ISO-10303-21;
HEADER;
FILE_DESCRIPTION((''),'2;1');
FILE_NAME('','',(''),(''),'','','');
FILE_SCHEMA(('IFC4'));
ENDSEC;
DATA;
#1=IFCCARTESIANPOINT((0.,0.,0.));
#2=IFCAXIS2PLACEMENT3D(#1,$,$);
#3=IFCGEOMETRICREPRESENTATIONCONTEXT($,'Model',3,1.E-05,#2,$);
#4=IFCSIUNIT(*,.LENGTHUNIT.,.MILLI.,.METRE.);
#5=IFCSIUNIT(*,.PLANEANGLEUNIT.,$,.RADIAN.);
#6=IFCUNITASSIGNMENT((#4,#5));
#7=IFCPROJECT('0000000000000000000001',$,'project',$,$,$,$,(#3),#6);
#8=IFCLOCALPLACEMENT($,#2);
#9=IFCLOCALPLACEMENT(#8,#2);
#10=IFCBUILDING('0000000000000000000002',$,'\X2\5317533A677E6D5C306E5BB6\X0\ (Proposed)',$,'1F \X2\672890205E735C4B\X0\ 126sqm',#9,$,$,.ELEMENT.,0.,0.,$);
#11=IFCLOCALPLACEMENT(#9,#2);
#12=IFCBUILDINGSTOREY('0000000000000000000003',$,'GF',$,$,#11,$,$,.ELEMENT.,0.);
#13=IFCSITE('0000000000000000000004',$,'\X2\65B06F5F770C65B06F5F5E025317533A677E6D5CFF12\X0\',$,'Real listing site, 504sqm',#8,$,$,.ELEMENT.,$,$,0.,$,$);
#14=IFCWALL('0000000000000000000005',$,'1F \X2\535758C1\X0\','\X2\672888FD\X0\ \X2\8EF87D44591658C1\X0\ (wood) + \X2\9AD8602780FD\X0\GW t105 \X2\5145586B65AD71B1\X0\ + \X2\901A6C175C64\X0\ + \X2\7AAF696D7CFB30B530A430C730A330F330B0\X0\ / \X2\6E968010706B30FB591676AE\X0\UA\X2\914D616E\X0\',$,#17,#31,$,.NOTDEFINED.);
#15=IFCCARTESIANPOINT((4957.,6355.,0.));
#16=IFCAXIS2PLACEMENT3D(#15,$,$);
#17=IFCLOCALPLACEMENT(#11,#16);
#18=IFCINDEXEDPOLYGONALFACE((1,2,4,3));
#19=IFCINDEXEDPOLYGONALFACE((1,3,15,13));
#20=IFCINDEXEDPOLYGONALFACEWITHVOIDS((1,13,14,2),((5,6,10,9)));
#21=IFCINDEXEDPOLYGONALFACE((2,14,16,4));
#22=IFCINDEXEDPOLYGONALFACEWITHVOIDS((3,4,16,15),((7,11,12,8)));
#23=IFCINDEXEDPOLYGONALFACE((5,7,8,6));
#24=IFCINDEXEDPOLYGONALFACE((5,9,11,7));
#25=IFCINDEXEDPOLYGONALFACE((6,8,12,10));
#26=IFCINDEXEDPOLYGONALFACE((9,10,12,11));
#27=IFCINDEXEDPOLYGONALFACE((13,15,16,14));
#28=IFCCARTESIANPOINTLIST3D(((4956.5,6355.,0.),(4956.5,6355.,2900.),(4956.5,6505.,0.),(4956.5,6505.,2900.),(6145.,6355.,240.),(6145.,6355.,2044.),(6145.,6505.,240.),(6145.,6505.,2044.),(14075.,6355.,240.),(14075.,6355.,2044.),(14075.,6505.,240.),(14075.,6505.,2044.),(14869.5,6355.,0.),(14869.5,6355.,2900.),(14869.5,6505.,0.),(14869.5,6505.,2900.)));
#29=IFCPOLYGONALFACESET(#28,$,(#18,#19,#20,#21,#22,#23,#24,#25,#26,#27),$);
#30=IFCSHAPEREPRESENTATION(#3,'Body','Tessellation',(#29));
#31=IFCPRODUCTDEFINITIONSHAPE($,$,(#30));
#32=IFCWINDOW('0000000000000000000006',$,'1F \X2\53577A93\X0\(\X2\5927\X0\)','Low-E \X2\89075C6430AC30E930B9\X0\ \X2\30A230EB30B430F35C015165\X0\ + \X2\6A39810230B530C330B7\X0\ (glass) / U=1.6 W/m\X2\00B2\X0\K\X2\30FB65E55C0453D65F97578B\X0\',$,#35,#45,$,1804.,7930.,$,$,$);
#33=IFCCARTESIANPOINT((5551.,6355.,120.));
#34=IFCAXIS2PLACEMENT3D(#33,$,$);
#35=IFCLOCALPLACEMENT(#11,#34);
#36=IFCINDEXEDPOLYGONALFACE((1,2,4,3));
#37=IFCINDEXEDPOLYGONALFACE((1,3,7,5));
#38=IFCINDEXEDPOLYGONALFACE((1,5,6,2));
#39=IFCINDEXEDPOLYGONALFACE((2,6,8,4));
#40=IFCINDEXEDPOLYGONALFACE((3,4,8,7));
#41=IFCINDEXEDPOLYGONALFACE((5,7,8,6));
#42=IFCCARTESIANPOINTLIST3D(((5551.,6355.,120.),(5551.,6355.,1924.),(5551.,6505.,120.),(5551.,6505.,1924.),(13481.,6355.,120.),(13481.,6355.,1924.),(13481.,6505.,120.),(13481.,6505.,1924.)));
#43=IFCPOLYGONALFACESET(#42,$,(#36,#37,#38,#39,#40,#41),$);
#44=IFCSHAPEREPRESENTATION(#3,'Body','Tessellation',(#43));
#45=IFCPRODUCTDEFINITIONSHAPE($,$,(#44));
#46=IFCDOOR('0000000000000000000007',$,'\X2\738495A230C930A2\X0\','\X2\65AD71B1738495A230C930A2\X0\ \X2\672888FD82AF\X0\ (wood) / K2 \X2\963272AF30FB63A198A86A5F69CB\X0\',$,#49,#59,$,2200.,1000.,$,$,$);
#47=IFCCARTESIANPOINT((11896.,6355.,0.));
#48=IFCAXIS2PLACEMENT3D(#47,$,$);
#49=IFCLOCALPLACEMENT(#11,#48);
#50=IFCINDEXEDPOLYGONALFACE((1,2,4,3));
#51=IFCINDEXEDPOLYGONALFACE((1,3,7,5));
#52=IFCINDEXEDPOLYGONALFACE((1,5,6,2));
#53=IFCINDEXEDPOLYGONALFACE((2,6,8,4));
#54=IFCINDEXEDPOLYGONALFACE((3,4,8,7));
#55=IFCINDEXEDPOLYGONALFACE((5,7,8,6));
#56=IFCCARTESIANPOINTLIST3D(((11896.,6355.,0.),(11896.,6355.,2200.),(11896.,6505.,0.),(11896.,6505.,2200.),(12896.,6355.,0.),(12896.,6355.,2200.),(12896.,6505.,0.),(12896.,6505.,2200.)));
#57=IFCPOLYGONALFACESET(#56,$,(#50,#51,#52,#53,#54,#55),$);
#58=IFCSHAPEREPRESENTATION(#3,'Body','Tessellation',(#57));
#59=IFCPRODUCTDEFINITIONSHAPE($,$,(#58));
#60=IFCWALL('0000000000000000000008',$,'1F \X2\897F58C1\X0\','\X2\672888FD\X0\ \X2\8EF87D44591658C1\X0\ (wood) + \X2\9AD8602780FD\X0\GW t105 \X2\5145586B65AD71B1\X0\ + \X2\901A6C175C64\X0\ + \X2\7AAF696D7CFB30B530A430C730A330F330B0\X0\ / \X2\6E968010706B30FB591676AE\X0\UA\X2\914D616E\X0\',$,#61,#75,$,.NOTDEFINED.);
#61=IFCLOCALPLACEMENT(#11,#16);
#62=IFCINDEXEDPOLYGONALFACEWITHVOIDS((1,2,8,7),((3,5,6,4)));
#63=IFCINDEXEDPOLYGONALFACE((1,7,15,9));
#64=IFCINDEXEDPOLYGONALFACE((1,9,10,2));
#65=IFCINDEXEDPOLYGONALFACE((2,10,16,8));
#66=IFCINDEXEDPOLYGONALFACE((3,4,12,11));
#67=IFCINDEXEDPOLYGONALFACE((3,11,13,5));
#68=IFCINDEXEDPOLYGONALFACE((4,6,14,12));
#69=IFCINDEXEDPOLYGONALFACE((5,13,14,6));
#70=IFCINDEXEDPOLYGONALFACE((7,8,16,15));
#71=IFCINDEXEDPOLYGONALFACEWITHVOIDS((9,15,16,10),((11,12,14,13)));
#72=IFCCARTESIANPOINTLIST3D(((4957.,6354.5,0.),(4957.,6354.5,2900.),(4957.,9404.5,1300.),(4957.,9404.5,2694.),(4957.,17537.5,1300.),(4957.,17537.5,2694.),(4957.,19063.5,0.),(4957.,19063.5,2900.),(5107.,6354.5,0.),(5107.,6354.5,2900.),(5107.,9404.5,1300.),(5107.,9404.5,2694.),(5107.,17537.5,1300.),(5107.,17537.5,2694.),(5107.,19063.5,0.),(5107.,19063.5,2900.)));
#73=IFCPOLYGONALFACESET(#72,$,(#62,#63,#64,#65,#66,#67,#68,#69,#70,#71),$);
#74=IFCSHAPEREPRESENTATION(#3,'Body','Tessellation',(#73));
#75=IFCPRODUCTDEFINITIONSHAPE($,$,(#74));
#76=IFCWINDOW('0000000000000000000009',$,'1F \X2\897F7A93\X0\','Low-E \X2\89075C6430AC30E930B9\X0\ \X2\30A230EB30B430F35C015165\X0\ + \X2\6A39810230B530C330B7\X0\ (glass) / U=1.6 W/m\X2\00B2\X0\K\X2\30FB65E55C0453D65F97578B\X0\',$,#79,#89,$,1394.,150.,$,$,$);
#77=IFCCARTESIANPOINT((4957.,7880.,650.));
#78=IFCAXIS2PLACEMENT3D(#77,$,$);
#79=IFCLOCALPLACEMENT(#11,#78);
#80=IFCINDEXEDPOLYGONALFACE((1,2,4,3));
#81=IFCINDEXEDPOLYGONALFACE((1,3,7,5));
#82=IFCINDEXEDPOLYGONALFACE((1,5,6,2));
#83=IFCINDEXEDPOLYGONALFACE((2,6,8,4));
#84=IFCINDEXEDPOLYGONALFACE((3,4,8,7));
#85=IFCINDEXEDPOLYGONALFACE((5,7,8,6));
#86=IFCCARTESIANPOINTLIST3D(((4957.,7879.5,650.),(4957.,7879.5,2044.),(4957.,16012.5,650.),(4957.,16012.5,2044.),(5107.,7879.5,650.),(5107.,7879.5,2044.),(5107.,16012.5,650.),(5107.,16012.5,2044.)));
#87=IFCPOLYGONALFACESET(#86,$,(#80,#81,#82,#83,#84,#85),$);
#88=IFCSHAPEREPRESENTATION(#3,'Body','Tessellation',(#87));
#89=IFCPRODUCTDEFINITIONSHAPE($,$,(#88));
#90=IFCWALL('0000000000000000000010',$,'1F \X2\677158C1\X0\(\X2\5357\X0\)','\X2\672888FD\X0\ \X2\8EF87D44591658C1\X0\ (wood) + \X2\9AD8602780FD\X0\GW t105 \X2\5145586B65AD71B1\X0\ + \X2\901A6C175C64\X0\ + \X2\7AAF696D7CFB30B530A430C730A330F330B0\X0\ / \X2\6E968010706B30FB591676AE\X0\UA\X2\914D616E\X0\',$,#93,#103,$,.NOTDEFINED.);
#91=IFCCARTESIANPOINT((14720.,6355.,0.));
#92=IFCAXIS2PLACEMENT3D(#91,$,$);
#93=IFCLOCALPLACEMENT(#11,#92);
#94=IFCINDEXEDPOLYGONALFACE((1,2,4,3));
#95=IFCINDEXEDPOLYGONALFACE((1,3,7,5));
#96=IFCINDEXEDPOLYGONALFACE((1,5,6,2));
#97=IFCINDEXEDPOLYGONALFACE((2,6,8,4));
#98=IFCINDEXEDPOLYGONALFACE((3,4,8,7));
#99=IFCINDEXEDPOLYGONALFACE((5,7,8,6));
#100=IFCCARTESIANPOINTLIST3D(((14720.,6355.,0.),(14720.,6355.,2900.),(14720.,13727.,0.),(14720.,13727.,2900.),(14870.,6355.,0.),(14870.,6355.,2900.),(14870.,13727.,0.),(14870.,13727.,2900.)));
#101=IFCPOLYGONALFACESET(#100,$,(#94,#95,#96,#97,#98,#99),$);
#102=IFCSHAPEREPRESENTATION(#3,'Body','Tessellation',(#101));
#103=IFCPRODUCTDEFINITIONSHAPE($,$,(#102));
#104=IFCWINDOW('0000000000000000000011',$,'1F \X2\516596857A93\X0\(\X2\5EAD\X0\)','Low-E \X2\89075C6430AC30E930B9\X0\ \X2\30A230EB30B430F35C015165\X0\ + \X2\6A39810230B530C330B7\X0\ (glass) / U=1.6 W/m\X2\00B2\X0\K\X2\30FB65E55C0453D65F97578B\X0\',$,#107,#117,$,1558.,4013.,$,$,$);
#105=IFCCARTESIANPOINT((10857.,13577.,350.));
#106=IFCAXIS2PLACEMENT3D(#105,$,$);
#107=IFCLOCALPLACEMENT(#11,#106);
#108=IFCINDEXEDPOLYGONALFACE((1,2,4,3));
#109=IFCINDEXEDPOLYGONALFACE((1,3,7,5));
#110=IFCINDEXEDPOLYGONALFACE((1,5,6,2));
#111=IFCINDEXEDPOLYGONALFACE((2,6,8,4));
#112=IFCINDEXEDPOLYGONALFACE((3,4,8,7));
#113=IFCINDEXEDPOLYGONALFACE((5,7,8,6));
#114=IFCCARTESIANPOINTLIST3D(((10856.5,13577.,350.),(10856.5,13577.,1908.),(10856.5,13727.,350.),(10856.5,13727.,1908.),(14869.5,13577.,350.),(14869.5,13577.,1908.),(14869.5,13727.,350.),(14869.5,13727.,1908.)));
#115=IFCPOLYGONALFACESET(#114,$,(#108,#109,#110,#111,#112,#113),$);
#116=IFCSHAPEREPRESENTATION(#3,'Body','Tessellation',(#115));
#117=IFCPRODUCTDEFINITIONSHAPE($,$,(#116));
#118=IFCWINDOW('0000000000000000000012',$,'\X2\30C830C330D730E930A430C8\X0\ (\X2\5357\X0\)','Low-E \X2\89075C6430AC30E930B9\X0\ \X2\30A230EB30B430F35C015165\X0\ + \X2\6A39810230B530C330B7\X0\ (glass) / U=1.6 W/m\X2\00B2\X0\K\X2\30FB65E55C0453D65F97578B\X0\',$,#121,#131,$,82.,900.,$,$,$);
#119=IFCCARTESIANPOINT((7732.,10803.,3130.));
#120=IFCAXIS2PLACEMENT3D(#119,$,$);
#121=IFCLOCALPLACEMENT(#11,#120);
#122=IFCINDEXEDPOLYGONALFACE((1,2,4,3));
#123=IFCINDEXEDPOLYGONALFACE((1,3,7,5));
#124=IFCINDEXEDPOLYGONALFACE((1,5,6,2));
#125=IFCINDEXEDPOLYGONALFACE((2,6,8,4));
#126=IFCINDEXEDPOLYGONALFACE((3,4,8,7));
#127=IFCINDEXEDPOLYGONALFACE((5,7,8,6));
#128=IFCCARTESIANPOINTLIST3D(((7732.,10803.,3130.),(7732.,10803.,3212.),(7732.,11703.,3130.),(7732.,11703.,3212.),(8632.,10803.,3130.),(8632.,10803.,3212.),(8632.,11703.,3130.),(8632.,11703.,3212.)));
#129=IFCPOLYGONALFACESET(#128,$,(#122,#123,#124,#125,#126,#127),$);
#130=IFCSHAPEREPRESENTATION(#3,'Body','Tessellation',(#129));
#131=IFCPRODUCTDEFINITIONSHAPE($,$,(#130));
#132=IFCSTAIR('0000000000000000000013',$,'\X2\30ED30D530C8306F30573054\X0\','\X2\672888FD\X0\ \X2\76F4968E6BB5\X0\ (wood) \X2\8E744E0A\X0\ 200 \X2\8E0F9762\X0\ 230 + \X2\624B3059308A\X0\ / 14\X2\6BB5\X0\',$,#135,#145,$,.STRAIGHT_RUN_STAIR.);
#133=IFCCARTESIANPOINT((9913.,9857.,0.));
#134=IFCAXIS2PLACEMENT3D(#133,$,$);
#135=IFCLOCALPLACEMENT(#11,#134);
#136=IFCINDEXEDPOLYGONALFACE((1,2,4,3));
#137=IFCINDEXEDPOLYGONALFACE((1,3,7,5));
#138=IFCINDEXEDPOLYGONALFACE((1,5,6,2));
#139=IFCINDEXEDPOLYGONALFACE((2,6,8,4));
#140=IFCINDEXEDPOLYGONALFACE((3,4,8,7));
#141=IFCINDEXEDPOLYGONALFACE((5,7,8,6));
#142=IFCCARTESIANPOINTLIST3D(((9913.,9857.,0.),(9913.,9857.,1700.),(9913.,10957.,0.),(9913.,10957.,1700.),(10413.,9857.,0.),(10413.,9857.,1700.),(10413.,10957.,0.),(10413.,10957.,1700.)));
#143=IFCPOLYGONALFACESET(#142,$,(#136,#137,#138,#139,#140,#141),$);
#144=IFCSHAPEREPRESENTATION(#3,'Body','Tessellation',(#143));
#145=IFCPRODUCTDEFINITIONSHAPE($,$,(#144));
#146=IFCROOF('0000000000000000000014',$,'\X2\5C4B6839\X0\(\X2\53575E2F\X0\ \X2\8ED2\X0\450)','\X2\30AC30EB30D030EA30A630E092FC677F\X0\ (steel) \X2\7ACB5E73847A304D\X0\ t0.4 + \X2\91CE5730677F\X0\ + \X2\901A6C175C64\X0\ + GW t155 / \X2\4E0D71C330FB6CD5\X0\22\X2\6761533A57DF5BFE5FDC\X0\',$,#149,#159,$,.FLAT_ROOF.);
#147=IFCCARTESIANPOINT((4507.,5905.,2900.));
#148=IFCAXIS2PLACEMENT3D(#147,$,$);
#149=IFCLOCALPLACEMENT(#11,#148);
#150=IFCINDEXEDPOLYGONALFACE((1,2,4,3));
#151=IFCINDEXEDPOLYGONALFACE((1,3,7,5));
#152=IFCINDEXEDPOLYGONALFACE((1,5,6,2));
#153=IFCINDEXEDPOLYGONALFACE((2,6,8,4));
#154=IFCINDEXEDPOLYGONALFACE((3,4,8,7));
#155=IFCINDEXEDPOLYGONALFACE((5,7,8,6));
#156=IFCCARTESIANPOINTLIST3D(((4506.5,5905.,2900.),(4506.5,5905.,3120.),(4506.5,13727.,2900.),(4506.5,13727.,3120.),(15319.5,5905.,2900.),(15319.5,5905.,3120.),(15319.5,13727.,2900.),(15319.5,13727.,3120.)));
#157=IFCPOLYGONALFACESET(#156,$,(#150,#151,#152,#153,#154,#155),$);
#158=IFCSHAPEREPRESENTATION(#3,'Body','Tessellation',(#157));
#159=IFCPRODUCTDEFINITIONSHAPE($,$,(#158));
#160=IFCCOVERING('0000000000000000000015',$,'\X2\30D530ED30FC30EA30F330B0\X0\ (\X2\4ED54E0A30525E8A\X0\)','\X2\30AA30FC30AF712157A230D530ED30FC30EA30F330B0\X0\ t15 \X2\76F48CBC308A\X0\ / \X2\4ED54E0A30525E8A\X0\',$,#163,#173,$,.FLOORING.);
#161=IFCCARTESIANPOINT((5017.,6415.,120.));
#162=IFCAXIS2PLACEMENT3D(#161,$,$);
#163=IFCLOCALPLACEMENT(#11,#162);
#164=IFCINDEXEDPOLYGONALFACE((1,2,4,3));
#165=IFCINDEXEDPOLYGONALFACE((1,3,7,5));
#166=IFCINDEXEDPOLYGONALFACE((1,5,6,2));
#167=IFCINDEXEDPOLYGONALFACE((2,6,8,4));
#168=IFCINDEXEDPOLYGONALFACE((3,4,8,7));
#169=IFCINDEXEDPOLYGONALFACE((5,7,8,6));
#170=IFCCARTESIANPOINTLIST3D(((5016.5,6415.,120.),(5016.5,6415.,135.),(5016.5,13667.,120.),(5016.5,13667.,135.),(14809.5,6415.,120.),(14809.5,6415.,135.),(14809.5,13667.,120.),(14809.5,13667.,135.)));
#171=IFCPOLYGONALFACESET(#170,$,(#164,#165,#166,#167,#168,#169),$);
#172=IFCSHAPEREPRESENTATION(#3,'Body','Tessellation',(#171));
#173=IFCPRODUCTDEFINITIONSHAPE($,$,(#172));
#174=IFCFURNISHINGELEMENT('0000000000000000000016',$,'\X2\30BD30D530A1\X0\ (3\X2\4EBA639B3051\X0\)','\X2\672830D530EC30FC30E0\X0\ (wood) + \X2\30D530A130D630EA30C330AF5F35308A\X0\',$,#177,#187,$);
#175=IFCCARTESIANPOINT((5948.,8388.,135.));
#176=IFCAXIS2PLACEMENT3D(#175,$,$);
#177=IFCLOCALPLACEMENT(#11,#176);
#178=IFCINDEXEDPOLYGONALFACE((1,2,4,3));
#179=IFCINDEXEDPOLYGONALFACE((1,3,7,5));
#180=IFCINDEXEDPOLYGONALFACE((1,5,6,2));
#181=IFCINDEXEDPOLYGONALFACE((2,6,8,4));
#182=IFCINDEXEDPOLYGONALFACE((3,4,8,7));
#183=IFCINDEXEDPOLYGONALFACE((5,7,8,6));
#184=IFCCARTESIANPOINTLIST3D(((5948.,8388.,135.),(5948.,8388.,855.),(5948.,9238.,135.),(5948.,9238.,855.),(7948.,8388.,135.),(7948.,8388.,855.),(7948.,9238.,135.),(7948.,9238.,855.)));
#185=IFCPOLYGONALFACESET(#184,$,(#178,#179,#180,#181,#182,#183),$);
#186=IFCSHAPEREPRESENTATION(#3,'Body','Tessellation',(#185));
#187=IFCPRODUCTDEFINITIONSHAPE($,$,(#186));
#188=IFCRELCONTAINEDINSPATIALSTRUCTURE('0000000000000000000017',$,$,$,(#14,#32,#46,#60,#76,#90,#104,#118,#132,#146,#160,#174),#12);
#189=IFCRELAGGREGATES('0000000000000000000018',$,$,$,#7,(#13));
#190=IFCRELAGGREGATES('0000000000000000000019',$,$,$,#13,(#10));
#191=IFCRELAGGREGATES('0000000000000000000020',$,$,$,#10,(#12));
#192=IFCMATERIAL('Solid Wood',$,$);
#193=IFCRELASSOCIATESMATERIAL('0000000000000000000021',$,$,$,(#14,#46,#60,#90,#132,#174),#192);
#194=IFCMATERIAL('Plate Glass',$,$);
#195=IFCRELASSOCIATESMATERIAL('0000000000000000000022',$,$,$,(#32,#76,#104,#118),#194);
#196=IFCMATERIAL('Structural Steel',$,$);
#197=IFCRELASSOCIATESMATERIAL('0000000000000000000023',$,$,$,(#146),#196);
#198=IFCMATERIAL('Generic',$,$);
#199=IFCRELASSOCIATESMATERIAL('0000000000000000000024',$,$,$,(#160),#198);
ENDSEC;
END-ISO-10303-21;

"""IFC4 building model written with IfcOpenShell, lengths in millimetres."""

from ifc_helpers import new_model, si_unit, frame, frame_2d, origin, place, context, project, spatial, rectangle, extrude, material, element, fill, save


model = new_model("IFC4")

# Units and contexts
model_context = context("Model", 3, precision=1e-05, world=origin())
ifc_project = project(units=[si_unit("LENGTHUNIT", "METRE", prefix="MILLI"), si_unit("PLANEANGLEUNIT", "RADIAN")], contexts=[model_context])

# Site, building, storey
site_placement = place(None, origin())
site = spatial("IfcSite", under=ifc_project, at=site_placement, Name="新潟県新潟市北区松浜２", ObjectType="Real listing site, 504sqm", CompositionType="ELEMENT", RefElevation=0.0)
building_placement = place(site_placement, origin())
building = spatial("IfcBuilding", under=site, at=building_placement, Name="北区松浜の家 (Proposed)", ObjectType="1F 木造平屋 126sqm", CompositionType="ELEMENT", ElevationOfRefHeight=0.0, ElevationOfTerrain=0.0)
storey_placement = place(building_placement, origin())
storey = spatial("IfcBuildingStorey", under=building, at=storey_placement, Name="GF", CompositionType="ELEMENT", Elevation=0.0)

# Shared definitions
ifc_material_1 = material(Name="Solid Wood")

# Wall, openings, window, door
wall_1_placement = place(storey_placement, frame((4957.0, 6355.0, 0.0)))
wall_1 = element("IfcWall", 1, at=wall_1_placement, inside=storey, material=ifc_material_1, Name="1F 南壁", Description="木製 軸組外壁 (wood) + 高性能GW t105 充填断熱 + 通気層 + 窯業系サイディング / 準耐火・外皮UA配慮", PredefinedType="NOTDEFINED", context=model_context, shape_type="SweptSolid", body=[
    extrude(rectangle(XDim=9913.0, YDim=150.0, at=frame_2d((4956.0, 75.0))), frame((4957.0, 6355.0, 0.0)), (0.0, 0.0, 1.0), 2900.0),
])
opening_1_placement = place(storey_placement, frame((5551.0, 6355.0, 120.0)))
opening_1 = element("IfcOpeningElement", 2, at=opening_1_placement, cuts=wall_1, PredefinedType="NOTDEFINED", context=model_context, shape_type="SweptSolid", body=[
    extrude(rectangle(XDim=7930.0, YDim=150.0, at=frame_2d((3965.0, 75.0))), frame((5551.0, 6355.0, 120.0)), (0.0, 0.0, 1.0), 1804.0),
])
opening_2_placement = place(storey_placement, frame((11896.0, 6355.0, 0.0)))
opening_2 = element("IfcOpeningElement", 3, at=opening_2_placement, cuts=wall_1, PredefinedType="NOTDEFINED", context=model_context, shape_type="SweptSolid", body=[
    extrude(rectangle(XDim=1000.0, YDim=150.0, at=frame_2d((500.0, 75.0))), frame((11896.0, 6355.0, 0.0)), (0.0, 0.0, 1.0), 2200.0),
])
ifc_material_2 = material(Name="Plate Glass")
window_1_placement = place(storey_placement, frame((5551.0, 6355.0, 120.0)))
window_1 = element("IfcWindow", 4, at=window_1_placement, inside=storey, material=ifc_material_2, Name="1F 南窓(大)", Description="Low-E 複層ガラス アルゴン封入 + 樹脂サッシ (glass) / U=1.6 W/m²K・日射取得型", OverallHeight=1804.0, OverallWidth=7930.0, context=model_context, shape_type="SweptSolid", body=[
    extrude(rectangle(XDim=7930.0, YDim=150.0, at=frame_2d((3965.0, 75.0))), frame((5551.0, 6355.0, 120.0)), (0.0, 0.0, 1.0), 1804.0),
])
fill(opening_1, window_1)
door_1_placement = place(storey_placement, frame((11896.0, 6355.0, 0.0)))
door_1 = element("IfcDoor", 5, at=door_1_placement, inside=storey, material=ifc_material_1, Name="玄関ドア", Description="断熱玄関ドア 木製芯 (wood) / K2 防犯・採風機構", OverallHeight=2200.0, OverallWidth=1000.0, context=model_context, shape_type="SweptSolid", body=[
    extrude(rectangle(XDim=1000.0, YDim=150.0, at=frame_2d((500.0, 75.0))), frame((11896.0, 6355.0, 0.0)), (0.0, 0.0, 1.0), 2200.0),
])
fill(opening_2, door_1)

# Walls, openings, windows
wall_2_placement = place(storey_placement, frame((4957.0, 6355.0, 0.0)))
wall_2 = element("IfcWall", 6, at=wall_2_placement, inside=storey, material=ifc_material_1, Name="1F 西壁", Description="木製 軸組外壁 (wood) + 高性能GW t105 充填断熱 + 通気層 + 窯業系サイディング / 準耐火・外皮UA配慮", PredefinedType="NOTDEFINED", context=model_context, shape_type="SweptSolid", body=[
    extrude(rectangle(XDim=150.0, YDim=12709.0, at=frame_2d((75.0, 6354.0))), frame((4957.0, 6355.0, 0.0)), (0.0, 0.0, 1.0), 2900.0),
])
opening_3_placement = place(storey_placement, frame((4957.0, 7880.0, 650.0)))
opening_3 = element("IfcOpeningElement", 7, at=opening_3_placement, cuts=wall_2, PredefinedType="NOTDEFINED", context=model_context, shape_type="SweptSolid", body=[
    extrude(rectangle(XDim=150.0, YDim=8133.0, at=frame_2d((75.0, 4066.0))), frame((4957.0, 7880.0, 650.0)), (0.0, 0.0, 1.0), 1394.0),
])
window_2_placement = place(storey_placement, frame((4957.0, 7880.0, 650.0)))
window_2 = element("IfcWindow", 8, at=window_2_placement, inside=storey, material=ifc_material_2, Name="1F 西窓", Description="Low-E 複層ガラス アルゴン封入 + 樹脂サッシ (glass) / U=1.6 W/m²K・日射取得型", OverallHeight=1394.0, OverallWidth=150.0, context=model_context, shape_type="SweptSolid", body=[
    extrude(rectangle(XDim=150.0, YDim=8133.0, at=frame_2d((75.0, 4066.0))), frame((4957.0, 7880.0, 650.0)), (0.0, 0.0, 1.0), 1394.0),
])
fill(opening_3, window_2)
wall_3_placement = place(storey_placement, frame((14720.0, 6355.0, 0.0)))
wall_3 = element("IfcWall", 9, at=wall_3_placement, inside=storey, material=ifc_material_1, Name="1F 東壁(南)", Description="木製 軸組外壁 (wood) + 高性能GW t105 充填断熱 + 通気層 + 窯業系サイディング / 準耐火・外皮UA配慮", PredefinedType="NOTDEFINED", context=model_context, shape_type="SweptSolid", body=[
    extrude(rectangle(XDim=150.0, YDim=7372.0, at=frame_2d((75.0, 3686.0))), frame((14720.0, 6355.0, 0.0)), (0.0, 0.0, 1.0), 2900.0),
])
opening_4_placement = place(storey_placement, frame((10857.0, 13577.0, 350.0)))
opening_4 = element("IfcOpeningElement", 10, at=opening_4_placement, cuts=wall_3, PredefinedType="NOTDEFINED", context=model_context, shape_type="SweptSolid", body=[
    extrude(rectangle(XDim=4013.0, YDim=150.0, at=frame_2d((2006.0, 75.0))), frame((10857.0, 13577.0, 350.0)), (0.0, 0.0, 1.0), 1558.0),
])
window_3_placement = place(storey_placement, frame((10857.0, 13577.0, 350.0)))
window_3 = element("IfcWindow", 11, at=window_3_placement, inside=storey, material=ifc_material_2, Name="1F 入隅窓(庭)", Description="Low-E 複層ガラス アルゴン封入 + 樹脂サッシ (glass) / U=1.6 W/m²K・日射取得型", OverallHeight=1558.0, OverallWidth=4013.0, context=model_context, shape_type="SweptSolid", body=[
    extrude(rectangle(XDim=4013.0, YDim=150.0, at=frame_2d((2006.0, 75.0))), frame((10857.0, 13577.0, 350.0)), (0.0, 0.0, 1.0), 1558.0),
])
fill(opening_4, window_3)

# Window
window_4_placement = place(storey_placement, frame((7732.0, 10803.0, 3130.0)))
element("IfcWindow", 12, at=window_4_placement, inside=storey, material=ifc_material_2, Name="トップライト (南)", Description="Low-E 複層ガラス アルゴン封入 + 樹脂サッシ (glass) / U=1.6 W/m²K・日射取得型", OverallHeight=82.0, OverallWidth=900.0, context=model_context, shape_type="SweptSolid", body=[
    extrude(rectangle(XDim=900.0, YDim=900.0, at=frame_2d((450.0, 450.0))), frame((7732.0, 10803.0, 3130.0)), (0.0, 0.0, 1.0), 82.0),
])

# Stair
stair_placement = place(storey_placement, frame((9913.0, 9857.0, 0.0)))
element("IfcStair", 13, at=stair_placement, inside=storey, material=ifc_material_1, Name="ロフトはしご", Description="木製 直階段 (wood) 蹴上 200 踏面 230 + 手すり / 14段", PredefinedType="STRAIGHT_RUN_STAIR", context=model_context, shape_type="SweptSolid", body=[
    extrude(rectangle(XDim=500.0, YDim=1100.0, at=frame_2d((250.0, 550.0))), frame((9913.0, 9857.0, 0.0)), (0.0, 0.0, 1.0), 1700.0),
])

# Roof
ifc_material_3 = material(Name="Structural Steel")
roof_placement = place(storey_placement, frame((4507.0, 5905.0, 2900.0)))
element("IfcRoof", 14, at=roof_placement, inside=storey, material=ifc_material_3, Name="屋根(南帯 軒450)", Description="ガルバリウム鋼板 (steel) 立平葺き t0.4 + 野地板 + 通気層 + GW t155 / 不燃・法22条区域対応", PredefinedType="FLAT_ROOF", context=model_context, shape_type="SweptSolid", body=[
    extrude(rectangle(XDim=10813.0, YDim=7822.0, at=frame_2d((5406.0, 3911.0))), frame((4507.0, 5905.0, 2900.0)), (0.0, 0.0, 1.0), 220.0),
])

# Covering
ifc_material_4 = material(Name="Generic")
covering_placement = place(storey_placement, frame((5017.0, 6415.0, 120.0)))
element("IfcCovering", 15, at=covering_placement, inside=storey, material=ifc_material_4, Name="フローリング (仕上げ床)", Description="オーク無垢フローリング t15 直貼り / 仕上げ床", PredefinedType="FLOORING", context=model_context, shape_type="SweptSolid", body=[
    extrude(rectangle(XDim=9793.0, YDim=7252.0, at=frame_2d((4896.0, 3626.0))), frame((5017.0, 6415.0, 120.0)), (0.0, 0.0, 1.0), 15.0),
])

# Furnishing element
furnishing_1_placement = place(storey_placement, frame((5948.0, 8388.0, 135.0)))
element("IfcFurnishingElement", 16, at=furnishing_1_placement, inside=storey, material=ifc_material_1, Name="ソファ (3人掛け)", Description="木フレーム (wood) + ファブリック張り", context=model_context, shape_type="SweptSolid", body=[
    extrude(rectangle(XDim=2000.0, YDim=850.0, at=frame_2d((1000.0, 425.0))), frame((5948.0, 8388.0, 135.0)), (0.0, 0.0, 1.0), 720.0),
])

save(model, "model.ifc")
